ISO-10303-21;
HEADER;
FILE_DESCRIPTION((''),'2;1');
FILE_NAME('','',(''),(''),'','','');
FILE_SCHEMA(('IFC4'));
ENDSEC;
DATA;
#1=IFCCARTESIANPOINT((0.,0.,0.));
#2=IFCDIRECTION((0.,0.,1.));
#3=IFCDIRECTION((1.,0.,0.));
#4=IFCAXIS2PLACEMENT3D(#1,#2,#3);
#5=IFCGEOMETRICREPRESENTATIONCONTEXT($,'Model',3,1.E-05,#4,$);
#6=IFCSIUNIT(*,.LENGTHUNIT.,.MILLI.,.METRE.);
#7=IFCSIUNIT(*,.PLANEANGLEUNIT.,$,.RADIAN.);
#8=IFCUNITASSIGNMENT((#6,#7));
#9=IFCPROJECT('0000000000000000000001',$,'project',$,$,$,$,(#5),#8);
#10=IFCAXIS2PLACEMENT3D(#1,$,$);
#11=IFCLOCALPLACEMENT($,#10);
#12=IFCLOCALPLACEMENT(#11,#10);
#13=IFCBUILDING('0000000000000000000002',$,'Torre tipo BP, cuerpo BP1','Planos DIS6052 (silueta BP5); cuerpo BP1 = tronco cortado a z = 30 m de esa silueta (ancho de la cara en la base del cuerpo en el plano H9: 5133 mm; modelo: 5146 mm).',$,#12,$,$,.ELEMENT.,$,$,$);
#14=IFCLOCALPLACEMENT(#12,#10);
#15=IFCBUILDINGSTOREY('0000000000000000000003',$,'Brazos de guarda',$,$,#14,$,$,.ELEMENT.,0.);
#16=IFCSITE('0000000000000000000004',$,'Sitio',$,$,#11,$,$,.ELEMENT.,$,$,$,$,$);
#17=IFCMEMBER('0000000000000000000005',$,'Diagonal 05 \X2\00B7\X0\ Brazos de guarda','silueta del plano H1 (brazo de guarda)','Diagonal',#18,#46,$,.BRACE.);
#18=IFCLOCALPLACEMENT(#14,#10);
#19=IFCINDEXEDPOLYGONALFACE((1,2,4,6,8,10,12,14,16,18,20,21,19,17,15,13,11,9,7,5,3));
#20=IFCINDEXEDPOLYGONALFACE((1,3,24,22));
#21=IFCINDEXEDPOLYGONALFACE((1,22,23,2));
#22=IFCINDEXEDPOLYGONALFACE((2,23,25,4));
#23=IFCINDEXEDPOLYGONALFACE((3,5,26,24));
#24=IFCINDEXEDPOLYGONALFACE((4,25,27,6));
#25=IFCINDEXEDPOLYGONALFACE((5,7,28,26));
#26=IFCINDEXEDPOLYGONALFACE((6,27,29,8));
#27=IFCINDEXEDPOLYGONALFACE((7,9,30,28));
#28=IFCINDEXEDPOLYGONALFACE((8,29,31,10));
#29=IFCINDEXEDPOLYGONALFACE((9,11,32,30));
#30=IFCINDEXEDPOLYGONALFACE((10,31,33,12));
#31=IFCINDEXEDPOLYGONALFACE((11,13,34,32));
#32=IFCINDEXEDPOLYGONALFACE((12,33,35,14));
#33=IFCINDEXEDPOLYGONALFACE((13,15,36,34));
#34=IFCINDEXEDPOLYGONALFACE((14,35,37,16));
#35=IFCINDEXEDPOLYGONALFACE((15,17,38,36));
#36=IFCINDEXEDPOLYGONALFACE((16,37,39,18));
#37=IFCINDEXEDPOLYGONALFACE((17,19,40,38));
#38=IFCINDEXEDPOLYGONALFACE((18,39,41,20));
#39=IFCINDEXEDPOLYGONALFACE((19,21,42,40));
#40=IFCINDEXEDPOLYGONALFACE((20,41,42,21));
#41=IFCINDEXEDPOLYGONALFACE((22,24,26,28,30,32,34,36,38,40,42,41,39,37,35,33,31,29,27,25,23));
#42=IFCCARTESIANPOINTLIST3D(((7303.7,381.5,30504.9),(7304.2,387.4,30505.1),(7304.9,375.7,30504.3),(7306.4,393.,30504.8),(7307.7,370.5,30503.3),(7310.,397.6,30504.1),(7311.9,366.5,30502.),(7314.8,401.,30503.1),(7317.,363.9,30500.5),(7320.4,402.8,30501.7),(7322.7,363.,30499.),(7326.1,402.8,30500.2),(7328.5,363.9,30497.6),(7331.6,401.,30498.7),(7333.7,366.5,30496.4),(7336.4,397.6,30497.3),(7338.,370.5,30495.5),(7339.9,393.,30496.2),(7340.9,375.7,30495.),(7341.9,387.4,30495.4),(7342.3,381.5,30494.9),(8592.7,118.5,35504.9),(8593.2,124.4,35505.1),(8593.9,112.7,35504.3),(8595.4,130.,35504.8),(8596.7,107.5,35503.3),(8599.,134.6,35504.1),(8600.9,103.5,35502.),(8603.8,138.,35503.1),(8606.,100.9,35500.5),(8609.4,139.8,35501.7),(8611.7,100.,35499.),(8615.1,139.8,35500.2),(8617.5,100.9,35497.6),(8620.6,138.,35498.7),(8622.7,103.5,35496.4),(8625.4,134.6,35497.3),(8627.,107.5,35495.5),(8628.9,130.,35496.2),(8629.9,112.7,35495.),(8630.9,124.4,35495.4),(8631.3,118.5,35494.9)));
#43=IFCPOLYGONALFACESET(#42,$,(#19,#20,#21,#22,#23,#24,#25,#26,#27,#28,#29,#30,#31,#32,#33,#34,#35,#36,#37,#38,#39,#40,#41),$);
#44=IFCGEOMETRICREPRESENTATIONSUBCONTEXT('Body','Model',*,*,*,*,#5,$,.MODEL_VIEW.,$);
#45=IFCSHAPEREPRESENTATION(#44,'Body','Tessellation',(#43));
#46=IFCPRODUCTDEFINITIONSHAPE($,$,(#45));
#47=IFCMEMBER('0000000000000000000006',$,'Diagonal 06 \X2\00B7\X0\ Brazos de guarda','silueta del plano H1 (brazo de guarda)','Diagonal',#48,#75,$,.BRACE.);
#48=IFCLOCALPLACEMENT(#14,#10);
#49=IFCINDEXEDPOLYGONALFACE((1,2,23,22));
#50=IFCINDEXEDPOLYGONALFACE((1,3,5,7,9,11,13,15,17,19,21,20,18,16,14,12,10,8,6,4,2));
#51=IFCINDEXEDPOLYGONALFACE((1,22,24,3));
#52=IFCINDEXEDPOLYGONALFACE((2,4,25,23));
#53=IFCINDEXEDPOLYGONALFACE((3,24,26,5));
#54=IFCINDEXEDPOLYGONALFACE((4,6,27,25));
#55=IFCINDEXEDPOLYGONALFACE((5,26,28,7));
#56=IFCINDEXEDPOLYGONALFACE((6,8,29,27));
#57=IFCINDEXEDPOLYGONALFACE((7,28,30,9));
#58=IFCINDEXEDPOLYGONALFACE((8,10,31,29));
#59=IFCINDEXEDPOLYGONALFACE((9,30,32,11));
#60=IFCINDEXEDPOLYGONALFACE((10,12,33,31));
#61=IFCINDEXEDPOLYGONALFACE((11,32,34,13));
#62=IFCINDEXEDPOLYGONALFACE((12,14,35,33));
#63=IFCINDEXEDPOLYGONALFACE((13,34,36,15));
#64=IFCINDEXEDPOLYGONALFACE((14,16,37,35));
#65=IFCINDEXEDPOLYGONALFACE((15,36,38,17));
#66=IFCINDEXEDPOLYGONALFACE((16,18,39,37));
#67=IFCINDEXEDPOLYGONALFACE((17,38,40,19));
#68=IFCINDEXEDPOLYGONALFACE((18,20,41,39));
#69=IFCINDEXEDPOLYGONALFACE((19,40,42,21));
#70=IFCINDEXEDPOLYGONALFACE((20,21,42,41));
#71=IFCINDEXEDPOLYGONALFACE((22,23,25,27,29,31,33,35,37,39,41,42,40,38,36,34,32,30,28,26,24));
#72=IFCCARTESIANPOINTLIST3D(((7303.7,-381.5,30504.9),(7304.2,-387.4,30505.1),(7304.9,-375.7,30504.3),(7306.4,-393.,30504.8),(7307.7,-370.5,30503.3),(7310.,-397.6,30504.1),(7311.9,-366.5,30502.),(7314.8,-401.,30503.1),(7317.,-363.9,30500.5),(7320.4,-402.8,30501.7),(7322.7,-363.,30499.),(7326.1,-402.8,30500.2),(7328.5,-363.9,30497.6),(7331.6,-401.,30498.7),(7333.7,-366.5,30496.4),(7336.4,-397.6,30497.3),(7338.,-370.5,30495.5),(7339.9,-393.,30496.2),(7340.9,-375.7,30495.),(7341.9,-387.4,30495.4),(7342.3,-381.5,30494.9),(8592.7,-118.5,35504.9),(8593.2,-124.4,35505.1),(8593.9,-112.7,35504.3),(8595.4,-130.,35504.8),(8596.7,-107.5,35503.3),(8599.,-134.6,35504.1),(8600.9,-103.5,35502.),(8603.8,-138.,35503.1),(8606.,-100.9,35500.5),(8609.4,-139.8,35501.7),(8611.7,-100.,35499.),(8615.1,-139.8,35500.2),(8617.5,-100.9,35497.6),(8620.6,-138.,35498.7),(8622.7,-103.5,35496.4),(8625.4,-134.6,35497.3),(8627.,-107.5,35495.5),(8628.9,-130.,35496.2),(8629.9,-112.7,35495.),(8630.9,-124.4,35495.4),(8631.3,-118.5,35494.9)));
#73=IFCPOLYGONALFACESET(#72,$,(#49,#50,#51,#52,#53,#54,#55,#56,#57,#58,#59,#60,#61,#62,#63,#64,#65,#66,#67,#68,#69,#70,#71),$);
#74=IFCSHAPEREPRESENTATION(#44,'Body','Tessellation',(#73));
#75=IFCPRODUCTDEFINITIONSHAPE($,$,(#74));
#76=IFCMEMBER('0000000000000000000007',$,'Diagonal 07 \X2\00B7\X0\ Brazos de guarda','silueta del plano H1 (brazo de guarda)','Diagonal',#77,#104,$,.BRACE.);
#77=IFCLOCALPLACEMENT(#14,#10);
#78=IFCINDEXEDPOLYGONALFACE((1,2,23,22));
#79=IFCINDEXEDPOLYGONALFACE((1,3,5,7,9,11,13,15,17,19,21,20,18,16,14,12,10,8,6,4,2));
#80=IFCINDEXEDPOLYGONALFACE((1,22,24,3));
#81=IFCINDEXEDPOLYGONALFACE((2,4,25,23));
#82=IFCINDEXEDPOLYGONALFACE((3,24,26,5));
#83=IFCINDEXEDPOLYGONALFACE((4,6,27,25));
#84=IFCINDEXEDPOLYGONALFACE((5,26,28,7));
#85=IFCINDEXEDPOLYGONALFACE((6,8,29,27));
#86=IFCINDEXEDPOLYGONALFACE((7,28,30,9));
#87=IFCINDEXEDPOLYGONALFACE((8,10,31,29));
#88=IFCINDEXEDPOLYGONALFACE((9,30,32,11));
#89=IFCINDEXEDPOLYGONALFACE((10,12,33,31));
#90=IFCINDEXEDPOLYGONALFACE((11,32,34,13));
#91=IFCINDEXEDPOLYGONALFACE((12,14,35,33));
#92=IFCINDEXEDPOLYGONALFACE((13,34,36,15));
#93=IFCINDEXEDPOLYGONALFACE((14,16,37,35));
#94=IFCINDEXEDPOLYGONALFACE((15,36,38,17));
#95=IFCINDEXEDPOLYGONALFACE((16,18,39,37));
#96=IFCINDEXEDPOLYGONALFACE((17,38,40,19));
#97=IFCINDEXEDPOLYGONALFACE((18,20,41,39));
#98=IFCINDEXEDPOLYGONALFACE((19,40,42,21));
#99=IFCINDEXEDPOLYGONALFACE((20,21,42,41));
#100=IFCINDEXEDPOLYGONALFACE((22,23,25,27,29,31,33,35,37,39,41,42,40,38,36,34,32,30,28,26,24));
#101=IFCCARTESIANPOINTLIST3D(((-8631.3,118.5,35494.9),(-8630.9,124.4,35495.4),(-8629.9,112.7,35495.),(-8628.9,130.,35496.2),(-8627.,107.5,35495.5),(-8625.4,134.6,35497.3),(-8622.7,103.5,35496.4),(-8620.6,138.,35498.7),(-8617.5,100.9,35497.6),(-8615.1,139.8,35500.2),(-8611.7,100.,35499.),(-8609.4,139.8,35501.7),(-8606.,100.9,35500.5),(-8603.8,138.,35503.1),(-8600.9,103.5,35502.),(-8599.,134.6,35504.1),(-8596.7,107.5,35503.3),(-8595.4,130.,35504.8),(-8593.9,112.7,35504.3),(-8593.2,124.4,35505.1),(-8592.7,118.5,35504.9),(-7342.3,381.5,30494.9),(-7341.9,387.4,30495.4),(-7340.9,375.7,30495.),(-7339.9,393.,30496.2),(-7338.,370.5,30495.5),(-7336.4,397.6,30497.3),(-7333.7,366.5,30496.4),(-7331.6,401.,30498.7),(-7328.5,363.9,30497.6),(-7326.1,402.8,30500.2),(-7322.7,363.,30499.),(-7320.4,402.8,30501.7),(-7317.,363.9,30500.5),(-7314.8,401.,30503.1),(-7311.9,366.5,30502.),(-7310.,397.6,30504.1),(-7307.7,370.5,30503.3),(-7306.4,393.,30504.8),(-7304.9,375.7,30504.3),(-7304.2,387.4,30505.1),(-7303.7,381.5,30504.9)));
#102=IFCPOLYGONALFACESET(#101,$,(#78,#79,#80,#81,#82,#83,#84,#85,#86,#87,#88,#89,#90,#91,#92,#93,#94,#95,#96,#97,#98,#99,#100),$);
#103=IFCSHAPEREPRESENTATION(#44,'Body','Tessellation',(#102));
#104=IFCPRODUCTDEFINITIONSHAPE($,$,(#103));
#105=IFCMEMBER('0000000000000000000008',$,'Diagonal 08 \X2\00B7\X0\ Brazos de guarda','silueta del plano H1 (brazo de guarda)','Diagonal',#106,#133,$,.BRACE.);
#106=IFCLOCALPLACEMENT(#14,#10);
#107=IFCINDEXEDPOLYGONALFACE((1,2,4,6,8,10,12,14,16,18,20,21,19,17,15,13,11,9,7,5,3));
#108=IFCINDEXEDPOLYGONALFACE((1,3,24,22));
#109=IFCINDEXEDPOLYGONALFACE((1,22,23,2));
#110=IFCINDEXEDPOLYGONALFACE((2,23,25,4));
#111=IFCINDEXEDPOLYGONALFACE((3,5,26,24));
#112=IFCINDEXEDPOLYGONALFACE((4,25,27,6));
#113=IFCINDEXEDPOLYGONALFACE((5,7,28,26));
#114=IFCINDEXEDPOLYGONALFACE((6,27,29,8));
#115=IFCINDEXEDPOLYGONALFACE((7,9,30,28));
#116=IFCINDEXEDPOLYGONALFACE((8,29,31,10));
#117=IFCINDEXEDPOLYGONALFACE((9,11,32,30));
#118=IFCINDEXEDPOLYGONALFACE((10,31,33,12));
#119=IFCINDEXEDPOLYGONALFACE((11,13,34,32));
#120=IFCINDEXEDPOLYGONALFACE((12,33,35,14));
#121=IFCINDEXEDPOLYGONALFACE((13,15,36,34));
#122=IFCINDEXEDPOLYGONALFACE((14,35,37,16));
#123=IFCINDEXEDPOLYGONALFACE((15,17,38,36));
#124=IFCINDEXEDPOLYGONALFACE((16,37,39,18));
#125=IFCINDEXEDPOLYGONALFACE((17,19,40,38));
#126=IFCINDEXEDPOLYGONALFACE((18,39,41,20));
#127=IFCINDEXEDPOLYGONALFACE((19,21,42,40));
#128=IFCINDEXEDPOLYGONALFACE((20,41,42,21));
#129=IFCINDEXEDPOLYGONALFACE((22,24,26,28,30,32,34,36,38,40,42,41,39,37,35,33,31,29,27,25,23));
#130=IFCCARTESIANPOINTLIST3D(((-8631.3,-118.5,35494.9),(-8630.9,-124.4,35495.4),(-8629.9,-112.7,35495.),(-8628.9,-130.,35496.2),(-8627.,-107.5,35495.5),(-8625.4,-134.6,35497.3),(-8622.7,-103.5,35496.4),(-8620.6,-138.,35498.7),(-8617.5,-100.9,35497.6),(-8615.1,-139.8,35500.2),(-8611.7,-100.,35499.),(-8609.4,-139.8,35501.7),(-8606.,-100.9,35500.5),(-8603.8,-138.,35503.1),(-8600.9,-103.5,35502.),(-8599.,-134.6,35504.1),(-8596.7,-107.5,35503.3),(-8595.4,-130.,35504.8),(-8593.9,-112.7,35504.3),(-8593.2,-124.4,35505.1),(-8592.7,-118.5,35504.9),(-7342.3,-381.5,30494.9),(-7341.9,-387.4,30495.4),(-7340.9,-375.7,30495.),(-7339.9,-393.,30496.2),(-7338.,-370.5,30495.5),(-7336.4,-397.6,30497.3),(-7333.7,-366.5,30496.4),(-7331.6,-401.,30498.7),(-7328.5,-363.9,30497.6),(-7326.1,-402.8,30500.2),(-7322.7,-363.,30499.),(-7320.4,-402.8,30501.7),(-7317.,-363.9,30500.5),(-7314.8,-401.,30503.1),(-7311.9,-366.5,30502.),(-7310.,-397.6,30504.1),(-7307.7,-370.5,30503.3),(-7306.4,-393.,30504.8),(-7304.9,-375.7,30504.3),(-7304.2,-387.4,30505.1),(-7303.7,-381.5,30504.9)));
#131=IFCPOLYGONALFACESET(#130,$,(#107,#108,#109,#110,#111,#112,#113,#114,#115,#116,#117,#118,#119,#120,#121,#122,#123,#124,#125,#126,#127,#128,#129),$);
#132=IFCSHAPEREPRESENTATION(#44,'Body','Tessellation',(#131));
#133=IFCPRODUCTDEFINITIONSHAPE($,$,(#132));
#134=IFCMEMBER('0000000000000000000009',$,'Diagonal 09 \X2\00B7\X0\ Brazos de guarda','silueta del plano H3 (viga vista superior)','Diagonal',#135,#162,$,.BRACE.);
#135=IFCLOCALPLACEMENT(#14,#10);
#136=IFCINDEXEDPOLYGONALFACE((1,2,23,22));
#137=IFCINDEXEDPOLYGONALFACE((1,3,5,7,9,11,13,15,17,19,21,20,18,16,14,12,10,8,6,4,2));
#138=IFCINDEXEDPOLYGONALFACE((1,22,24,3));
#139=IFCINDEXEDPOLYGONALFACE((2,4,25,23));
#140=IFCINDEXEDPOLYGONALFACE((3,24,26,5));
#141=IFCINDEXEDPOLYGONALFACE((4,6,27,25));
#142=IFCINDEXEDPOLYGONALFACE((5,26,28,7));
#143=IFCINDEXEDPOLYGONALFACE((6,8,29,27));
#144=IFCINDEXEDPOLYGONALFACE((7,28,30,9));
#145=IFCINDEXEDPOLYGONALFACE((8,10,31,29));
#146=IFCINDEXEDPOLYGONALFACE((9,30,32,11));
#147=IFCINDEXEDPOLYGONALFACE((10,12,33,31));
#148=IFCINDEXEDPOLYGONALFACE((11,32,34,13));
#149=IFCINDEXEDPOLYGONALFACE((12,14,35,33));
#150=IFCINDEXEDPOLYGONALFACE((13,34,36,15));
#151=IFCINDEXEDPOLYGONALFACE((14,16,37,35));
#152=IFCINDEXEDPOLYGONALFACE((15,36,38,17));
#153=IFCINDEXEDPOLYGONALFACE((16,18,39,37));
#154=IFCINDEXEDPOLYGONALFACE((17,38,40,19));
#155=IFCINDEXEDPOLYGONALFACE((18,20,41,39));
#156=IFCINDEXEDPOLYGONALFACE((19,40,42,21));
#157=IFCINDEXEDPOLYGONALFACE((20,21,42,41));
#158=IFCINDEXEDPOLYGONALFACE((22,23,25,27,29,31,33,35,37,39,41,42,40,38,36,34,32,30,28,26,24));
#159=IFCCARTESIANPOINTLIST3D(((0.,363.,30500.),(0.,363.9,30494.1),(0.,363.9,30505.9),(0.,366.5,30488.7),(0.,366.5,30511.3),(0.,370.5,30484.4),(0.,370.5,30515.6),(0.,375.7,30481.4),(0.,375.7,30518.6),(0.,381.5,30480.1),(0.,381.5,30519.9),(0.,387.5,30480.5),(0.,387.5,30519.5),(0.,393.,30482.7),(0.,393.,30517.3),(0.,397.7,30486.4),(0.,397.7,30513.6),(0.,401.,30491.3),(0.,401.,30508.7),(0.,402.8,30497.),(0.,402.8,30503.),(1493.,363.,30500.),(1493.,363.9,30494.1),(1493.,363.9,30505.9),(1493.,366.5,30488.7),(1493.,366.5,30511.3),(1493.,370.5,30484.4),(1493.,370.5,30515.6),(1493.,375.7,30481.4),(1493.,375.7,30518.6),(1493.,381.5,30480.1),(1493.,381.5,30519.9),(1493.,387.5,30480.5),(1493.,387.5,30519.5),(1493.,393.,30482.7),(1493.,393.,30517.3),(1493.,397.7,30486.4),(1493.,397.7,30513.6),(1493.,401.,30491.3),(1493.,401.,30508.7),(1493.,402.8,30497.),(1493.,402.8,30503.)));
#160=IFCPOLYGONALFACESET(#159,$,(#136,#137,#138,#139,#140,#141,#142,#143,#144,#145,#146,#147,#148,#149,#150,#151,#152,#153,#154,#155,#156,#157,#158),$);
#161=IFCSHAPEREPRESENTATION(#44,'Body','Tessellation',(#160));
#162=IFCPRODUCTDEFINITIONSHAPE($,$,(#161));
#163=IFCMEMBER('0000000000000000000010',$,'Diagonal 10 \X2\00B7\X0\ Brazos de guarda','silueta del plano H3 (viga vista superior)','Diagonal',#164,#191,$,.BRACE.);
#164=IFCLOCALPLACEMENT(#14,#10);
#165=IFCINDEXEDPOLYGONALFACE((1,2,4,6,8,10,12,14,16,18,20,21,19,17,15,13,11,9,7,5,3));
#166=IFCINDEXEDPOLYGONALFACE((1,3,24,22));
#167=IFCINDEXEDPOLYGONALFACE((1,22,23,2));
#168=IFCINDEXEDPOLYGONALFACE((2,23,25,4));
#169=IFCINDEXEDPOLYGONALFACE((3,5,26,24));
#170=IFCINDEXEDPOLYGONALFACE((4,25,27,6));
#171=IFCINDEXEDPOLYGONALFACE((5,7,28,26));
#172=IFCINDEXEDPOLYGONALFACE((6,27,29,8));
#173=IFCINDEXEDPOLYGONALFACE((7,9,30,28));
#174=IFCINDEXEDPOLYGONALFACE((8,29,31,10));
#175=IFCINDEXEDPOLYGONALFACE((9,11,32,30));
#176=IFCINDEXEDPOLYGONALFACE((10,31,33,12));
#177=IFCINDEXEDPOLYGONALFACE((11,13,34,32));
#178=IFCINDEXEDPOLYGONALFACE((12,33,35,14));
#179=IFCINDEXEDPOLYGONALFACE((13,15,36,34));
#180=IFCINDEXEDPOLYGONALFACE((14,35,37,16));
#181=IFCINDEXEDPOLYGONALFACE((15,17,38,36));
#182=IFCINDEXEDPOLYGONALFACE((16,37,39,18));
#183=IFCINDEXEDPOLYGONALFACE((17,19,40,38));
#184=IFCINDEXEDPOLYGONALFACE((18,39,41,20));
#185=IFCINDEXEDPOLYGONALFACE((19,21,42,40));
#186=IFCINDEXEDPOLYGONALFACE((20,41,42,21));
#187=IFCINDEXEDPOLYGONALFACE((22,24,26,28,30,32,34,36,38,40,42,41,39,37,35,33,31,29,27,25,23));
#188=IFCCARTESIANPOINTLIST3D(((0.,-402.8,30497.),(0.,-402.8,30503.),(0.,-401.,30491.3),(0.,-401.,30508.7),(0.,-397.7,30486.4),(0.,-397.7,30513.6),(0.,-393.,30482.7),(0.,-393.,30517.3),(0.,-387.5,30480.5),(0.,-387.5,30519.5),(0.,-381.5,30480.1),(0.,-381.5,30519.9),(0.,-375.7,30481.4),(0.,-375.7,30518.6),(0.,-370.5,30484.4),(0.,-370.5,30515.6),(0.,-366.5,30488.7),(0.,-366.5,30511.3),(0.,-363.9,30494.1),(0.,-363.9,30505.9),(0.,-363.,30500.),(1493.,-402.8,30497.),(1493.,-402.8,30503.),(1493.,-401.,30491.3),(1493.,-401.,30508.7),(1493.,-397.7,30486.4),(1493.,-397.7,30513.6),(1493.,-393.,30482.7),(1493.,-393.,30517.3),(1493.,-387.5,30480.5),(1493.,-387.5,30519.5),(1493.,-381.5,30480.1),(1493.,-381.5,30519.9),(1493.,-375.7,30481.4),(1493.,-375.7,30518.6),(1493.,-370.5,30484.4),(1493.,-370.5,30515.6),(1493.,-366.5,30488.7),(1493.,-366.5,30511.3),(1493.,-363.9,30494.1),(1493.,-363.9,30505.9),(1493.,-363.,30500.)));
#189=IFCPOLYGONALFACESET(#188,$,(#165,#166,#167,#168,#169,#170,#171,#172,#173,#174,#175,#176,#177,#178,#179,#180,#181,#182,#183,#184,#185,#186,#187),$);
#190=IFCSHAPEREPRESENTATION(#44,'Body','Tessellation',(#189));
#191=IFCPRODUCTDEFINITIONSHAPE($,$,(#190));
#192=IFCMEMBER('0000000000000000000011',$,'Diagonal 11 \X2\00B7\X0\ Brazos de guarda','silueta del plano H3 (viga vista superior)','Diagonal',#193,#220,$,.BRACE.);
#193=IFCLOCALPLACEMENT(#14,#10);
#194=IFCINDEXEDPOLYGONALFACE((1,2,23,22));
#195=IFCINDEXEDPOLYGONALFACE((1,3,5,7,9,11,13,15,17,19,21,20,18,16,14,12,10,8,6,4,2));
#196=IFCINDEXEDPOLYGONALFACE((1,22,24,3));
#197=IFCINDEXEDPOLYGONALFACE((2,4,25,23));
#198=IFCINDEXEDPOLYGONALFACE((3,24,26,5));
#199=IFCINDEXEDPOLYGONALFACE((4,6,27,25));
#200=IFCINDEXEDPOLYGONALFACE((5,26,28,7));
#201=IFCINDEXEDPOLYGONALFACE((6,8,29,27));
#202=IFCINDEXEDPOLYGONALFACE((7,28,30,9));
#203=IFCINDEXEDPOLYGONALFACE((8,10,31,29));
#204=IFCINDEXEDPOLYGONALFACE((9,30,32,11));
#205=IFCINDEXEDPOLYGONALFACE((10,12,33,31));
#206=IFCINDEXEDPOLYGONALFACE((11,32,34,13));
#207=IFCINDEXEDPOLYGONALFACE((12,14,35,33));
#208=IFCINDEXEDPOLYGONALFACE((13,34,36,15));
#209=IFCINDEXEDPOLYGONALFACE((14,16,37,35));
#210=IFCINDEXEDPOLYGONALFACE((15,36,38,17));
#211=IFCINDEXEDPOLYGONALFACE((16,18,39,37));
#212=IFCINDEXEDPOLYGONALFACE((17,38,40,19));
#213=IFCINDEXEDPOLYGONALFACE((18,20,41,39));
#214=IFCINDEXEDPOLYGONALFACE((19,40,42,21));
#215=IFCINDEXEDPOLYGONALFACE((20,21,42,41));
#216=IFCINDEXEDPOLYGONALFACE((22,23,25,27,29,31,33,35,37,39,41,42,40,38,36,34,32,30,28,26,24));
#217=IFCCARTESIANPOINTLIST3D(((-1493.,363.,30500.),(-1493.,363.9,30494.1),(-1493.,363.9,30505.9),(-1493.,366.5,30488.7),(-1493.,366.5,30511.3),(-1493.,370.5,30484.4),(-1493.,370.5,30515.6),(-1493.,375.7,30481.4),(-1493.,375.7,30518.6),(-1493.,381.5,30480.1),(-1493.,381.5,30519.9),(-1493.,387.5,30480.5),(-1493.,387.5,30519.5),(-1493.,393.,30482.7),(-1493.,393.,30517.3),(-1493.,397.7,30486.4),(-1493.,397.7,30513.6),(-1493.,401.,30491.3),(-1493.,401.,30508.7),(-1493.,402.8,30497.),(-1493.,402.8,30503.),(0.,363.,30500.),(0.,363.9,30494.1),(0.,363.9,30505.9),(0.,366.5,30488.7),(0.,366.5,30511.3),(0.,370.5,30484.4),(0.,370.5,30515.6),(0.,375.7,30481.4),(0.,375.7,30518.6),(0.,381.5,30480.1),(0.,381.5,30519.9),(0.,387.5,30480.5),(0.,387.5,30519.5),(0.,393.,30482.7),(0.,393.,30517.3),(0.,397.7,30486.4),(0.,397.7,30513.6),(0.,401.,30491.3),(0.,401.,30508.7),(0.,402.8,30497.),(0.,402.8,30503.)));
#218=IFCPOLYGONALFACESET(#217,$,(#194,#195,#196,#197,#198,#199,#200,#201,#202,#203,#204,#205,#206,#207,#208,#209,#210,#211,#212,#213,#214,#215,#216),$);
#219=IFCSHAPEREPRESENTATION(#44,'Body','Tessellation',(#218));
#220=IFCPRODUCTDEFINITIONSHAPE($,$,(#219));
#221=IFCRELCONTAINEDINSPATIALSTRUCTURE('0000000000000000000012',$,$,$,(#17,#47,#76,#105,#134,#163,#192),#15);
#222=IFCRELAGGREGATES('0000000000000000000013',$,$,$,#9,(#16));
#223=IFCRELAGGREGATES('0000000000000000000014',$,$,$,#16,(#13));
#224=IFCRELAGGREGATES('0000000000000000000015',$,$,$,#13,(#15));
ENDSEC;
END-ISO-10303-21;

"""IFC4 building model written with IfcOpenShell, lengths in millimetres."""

from ifc_helpers import new_model, si_unit, frame, origin, origin_with_axes, place, context, subcontext, project, spatial, circle, extrude, element, save


model = new_model("IFC4")

# Units and contexts
model_context = context("Model", 3, precision=1e-05, world=origin_with_axes())
body_context = subcontext(model_context, "Body", "Model", "MODEL_VIEW")
ifc_project = project(units=[si_unit("LENGTHUNIT", "METRE", prefix="MILLI"), si_unit("PLANEANGLEUNIT", "RADIAN")], contexts=[model_context])

# Site, building, storey
site_placement = place(None, origin())
site = spatial("IfcSite", under=ifc_project, at=site_placement, Name="Sitio", CompositionType="ELEMENT")
building_placement = place(site_placement, origin())
building = spatial("IfcBuilding", under=site, at=building_placement, Name="Torre tipo BP, cuerpo BP1", Description="Planos DIS6052 (silueta BP5); cuerpo BP1 = tronco cortado a z = 30 m de esa silueta (ancho de la cara en la base del cuerpo en el plano H9: 5133 mm; modelo: 5146 mm).", CompositionType="ELEMENT")
storey_placement = place(building_placement, origin())
storey = spatial("IfcBuildingStorey", under=building, at=storey_placement, Name="Brazos de guarda", CompositionType="ELEMENT", Elevation=0.0)

# Members
for number, where, z_axis, x_axis, name in (
    (1, (7323.0, 383.0, 30500.0), (0.249315, -0.050869, 0.967086), (-0.012699, -0.998705, -0.049258), "Diagonal 05 · Brazos de guarda"),
    (2, (7323.0, -383.0, 30500.0), (0.249315, 0.050869, 0.967086), (-0.012699, 0.998705, -0.049258), "Diagonal 06 · Brazos de guarda"),
    (3, (-7323.0, 383.0, 30500.0), (-0.249315, -0.050869, 0.967086), (0.012699, -0.998705, -0.049258), "Diagonal 07 · Brazos de guarda"),
    (4, (-7323.0, -383.0, 30500.0), (-0.249315, 0.050869, 0.967086), (0.012699, 0.998705, -0.049258), "Diagonal 08 · Brazos de guarda"),
):
    element("IfcMember", number, at=place(storey_placement, frame(where, z_axis=z_axis, x_axis=x_axis)), inside=storey, Name=name, Description="silueta del plano H1 (brazo de guarda)", ObjectType="Diagonal", PredefinedType="BRACE", context=body_context, shape_type="SweptSolid", body=[
        extrude(circle(Radius=20.0), None, (0.0, 0.0, 1.0), 5170.2),
    ])
for number, where, z_axis, x_axis, name in (
    (5, (0.0, 383.0, 30500.0), (1.0, 0.0, 0.0), (0.0, -1.0, 0.0), "Diagonal 09 · Brazos de guarda"),
    (6, (0.0, -383.0, 30500.0), (1.0, 0.0, 0.0), (0.0, 1.0, 0.0), "Diagonal 10 · Brazos de guarda"),
    (7, (0.0, 383.0, 30500.0), (-1.0, 0.0, 0.0), (0.0, -1.0, 0.0), "Diagonal 11 · Brazos de guarda"),
):
    element("IfcMember", number, at=place(storey_placement, frame(where, z_axis=z_axis, x_axis=x_axis)), inside=storey, Name=name, Description="silueta del plano H3 (viga vista superior)", ObjectType="Diagonal", PredefinedType="BRACE", context=body_context, shape_type="SweptSolid", body=[
        extrude(circle(Radius=20.0), None, (0.0, 0.0, 1.0), 1493.0),
    ])

save(model, "model.ifc")
